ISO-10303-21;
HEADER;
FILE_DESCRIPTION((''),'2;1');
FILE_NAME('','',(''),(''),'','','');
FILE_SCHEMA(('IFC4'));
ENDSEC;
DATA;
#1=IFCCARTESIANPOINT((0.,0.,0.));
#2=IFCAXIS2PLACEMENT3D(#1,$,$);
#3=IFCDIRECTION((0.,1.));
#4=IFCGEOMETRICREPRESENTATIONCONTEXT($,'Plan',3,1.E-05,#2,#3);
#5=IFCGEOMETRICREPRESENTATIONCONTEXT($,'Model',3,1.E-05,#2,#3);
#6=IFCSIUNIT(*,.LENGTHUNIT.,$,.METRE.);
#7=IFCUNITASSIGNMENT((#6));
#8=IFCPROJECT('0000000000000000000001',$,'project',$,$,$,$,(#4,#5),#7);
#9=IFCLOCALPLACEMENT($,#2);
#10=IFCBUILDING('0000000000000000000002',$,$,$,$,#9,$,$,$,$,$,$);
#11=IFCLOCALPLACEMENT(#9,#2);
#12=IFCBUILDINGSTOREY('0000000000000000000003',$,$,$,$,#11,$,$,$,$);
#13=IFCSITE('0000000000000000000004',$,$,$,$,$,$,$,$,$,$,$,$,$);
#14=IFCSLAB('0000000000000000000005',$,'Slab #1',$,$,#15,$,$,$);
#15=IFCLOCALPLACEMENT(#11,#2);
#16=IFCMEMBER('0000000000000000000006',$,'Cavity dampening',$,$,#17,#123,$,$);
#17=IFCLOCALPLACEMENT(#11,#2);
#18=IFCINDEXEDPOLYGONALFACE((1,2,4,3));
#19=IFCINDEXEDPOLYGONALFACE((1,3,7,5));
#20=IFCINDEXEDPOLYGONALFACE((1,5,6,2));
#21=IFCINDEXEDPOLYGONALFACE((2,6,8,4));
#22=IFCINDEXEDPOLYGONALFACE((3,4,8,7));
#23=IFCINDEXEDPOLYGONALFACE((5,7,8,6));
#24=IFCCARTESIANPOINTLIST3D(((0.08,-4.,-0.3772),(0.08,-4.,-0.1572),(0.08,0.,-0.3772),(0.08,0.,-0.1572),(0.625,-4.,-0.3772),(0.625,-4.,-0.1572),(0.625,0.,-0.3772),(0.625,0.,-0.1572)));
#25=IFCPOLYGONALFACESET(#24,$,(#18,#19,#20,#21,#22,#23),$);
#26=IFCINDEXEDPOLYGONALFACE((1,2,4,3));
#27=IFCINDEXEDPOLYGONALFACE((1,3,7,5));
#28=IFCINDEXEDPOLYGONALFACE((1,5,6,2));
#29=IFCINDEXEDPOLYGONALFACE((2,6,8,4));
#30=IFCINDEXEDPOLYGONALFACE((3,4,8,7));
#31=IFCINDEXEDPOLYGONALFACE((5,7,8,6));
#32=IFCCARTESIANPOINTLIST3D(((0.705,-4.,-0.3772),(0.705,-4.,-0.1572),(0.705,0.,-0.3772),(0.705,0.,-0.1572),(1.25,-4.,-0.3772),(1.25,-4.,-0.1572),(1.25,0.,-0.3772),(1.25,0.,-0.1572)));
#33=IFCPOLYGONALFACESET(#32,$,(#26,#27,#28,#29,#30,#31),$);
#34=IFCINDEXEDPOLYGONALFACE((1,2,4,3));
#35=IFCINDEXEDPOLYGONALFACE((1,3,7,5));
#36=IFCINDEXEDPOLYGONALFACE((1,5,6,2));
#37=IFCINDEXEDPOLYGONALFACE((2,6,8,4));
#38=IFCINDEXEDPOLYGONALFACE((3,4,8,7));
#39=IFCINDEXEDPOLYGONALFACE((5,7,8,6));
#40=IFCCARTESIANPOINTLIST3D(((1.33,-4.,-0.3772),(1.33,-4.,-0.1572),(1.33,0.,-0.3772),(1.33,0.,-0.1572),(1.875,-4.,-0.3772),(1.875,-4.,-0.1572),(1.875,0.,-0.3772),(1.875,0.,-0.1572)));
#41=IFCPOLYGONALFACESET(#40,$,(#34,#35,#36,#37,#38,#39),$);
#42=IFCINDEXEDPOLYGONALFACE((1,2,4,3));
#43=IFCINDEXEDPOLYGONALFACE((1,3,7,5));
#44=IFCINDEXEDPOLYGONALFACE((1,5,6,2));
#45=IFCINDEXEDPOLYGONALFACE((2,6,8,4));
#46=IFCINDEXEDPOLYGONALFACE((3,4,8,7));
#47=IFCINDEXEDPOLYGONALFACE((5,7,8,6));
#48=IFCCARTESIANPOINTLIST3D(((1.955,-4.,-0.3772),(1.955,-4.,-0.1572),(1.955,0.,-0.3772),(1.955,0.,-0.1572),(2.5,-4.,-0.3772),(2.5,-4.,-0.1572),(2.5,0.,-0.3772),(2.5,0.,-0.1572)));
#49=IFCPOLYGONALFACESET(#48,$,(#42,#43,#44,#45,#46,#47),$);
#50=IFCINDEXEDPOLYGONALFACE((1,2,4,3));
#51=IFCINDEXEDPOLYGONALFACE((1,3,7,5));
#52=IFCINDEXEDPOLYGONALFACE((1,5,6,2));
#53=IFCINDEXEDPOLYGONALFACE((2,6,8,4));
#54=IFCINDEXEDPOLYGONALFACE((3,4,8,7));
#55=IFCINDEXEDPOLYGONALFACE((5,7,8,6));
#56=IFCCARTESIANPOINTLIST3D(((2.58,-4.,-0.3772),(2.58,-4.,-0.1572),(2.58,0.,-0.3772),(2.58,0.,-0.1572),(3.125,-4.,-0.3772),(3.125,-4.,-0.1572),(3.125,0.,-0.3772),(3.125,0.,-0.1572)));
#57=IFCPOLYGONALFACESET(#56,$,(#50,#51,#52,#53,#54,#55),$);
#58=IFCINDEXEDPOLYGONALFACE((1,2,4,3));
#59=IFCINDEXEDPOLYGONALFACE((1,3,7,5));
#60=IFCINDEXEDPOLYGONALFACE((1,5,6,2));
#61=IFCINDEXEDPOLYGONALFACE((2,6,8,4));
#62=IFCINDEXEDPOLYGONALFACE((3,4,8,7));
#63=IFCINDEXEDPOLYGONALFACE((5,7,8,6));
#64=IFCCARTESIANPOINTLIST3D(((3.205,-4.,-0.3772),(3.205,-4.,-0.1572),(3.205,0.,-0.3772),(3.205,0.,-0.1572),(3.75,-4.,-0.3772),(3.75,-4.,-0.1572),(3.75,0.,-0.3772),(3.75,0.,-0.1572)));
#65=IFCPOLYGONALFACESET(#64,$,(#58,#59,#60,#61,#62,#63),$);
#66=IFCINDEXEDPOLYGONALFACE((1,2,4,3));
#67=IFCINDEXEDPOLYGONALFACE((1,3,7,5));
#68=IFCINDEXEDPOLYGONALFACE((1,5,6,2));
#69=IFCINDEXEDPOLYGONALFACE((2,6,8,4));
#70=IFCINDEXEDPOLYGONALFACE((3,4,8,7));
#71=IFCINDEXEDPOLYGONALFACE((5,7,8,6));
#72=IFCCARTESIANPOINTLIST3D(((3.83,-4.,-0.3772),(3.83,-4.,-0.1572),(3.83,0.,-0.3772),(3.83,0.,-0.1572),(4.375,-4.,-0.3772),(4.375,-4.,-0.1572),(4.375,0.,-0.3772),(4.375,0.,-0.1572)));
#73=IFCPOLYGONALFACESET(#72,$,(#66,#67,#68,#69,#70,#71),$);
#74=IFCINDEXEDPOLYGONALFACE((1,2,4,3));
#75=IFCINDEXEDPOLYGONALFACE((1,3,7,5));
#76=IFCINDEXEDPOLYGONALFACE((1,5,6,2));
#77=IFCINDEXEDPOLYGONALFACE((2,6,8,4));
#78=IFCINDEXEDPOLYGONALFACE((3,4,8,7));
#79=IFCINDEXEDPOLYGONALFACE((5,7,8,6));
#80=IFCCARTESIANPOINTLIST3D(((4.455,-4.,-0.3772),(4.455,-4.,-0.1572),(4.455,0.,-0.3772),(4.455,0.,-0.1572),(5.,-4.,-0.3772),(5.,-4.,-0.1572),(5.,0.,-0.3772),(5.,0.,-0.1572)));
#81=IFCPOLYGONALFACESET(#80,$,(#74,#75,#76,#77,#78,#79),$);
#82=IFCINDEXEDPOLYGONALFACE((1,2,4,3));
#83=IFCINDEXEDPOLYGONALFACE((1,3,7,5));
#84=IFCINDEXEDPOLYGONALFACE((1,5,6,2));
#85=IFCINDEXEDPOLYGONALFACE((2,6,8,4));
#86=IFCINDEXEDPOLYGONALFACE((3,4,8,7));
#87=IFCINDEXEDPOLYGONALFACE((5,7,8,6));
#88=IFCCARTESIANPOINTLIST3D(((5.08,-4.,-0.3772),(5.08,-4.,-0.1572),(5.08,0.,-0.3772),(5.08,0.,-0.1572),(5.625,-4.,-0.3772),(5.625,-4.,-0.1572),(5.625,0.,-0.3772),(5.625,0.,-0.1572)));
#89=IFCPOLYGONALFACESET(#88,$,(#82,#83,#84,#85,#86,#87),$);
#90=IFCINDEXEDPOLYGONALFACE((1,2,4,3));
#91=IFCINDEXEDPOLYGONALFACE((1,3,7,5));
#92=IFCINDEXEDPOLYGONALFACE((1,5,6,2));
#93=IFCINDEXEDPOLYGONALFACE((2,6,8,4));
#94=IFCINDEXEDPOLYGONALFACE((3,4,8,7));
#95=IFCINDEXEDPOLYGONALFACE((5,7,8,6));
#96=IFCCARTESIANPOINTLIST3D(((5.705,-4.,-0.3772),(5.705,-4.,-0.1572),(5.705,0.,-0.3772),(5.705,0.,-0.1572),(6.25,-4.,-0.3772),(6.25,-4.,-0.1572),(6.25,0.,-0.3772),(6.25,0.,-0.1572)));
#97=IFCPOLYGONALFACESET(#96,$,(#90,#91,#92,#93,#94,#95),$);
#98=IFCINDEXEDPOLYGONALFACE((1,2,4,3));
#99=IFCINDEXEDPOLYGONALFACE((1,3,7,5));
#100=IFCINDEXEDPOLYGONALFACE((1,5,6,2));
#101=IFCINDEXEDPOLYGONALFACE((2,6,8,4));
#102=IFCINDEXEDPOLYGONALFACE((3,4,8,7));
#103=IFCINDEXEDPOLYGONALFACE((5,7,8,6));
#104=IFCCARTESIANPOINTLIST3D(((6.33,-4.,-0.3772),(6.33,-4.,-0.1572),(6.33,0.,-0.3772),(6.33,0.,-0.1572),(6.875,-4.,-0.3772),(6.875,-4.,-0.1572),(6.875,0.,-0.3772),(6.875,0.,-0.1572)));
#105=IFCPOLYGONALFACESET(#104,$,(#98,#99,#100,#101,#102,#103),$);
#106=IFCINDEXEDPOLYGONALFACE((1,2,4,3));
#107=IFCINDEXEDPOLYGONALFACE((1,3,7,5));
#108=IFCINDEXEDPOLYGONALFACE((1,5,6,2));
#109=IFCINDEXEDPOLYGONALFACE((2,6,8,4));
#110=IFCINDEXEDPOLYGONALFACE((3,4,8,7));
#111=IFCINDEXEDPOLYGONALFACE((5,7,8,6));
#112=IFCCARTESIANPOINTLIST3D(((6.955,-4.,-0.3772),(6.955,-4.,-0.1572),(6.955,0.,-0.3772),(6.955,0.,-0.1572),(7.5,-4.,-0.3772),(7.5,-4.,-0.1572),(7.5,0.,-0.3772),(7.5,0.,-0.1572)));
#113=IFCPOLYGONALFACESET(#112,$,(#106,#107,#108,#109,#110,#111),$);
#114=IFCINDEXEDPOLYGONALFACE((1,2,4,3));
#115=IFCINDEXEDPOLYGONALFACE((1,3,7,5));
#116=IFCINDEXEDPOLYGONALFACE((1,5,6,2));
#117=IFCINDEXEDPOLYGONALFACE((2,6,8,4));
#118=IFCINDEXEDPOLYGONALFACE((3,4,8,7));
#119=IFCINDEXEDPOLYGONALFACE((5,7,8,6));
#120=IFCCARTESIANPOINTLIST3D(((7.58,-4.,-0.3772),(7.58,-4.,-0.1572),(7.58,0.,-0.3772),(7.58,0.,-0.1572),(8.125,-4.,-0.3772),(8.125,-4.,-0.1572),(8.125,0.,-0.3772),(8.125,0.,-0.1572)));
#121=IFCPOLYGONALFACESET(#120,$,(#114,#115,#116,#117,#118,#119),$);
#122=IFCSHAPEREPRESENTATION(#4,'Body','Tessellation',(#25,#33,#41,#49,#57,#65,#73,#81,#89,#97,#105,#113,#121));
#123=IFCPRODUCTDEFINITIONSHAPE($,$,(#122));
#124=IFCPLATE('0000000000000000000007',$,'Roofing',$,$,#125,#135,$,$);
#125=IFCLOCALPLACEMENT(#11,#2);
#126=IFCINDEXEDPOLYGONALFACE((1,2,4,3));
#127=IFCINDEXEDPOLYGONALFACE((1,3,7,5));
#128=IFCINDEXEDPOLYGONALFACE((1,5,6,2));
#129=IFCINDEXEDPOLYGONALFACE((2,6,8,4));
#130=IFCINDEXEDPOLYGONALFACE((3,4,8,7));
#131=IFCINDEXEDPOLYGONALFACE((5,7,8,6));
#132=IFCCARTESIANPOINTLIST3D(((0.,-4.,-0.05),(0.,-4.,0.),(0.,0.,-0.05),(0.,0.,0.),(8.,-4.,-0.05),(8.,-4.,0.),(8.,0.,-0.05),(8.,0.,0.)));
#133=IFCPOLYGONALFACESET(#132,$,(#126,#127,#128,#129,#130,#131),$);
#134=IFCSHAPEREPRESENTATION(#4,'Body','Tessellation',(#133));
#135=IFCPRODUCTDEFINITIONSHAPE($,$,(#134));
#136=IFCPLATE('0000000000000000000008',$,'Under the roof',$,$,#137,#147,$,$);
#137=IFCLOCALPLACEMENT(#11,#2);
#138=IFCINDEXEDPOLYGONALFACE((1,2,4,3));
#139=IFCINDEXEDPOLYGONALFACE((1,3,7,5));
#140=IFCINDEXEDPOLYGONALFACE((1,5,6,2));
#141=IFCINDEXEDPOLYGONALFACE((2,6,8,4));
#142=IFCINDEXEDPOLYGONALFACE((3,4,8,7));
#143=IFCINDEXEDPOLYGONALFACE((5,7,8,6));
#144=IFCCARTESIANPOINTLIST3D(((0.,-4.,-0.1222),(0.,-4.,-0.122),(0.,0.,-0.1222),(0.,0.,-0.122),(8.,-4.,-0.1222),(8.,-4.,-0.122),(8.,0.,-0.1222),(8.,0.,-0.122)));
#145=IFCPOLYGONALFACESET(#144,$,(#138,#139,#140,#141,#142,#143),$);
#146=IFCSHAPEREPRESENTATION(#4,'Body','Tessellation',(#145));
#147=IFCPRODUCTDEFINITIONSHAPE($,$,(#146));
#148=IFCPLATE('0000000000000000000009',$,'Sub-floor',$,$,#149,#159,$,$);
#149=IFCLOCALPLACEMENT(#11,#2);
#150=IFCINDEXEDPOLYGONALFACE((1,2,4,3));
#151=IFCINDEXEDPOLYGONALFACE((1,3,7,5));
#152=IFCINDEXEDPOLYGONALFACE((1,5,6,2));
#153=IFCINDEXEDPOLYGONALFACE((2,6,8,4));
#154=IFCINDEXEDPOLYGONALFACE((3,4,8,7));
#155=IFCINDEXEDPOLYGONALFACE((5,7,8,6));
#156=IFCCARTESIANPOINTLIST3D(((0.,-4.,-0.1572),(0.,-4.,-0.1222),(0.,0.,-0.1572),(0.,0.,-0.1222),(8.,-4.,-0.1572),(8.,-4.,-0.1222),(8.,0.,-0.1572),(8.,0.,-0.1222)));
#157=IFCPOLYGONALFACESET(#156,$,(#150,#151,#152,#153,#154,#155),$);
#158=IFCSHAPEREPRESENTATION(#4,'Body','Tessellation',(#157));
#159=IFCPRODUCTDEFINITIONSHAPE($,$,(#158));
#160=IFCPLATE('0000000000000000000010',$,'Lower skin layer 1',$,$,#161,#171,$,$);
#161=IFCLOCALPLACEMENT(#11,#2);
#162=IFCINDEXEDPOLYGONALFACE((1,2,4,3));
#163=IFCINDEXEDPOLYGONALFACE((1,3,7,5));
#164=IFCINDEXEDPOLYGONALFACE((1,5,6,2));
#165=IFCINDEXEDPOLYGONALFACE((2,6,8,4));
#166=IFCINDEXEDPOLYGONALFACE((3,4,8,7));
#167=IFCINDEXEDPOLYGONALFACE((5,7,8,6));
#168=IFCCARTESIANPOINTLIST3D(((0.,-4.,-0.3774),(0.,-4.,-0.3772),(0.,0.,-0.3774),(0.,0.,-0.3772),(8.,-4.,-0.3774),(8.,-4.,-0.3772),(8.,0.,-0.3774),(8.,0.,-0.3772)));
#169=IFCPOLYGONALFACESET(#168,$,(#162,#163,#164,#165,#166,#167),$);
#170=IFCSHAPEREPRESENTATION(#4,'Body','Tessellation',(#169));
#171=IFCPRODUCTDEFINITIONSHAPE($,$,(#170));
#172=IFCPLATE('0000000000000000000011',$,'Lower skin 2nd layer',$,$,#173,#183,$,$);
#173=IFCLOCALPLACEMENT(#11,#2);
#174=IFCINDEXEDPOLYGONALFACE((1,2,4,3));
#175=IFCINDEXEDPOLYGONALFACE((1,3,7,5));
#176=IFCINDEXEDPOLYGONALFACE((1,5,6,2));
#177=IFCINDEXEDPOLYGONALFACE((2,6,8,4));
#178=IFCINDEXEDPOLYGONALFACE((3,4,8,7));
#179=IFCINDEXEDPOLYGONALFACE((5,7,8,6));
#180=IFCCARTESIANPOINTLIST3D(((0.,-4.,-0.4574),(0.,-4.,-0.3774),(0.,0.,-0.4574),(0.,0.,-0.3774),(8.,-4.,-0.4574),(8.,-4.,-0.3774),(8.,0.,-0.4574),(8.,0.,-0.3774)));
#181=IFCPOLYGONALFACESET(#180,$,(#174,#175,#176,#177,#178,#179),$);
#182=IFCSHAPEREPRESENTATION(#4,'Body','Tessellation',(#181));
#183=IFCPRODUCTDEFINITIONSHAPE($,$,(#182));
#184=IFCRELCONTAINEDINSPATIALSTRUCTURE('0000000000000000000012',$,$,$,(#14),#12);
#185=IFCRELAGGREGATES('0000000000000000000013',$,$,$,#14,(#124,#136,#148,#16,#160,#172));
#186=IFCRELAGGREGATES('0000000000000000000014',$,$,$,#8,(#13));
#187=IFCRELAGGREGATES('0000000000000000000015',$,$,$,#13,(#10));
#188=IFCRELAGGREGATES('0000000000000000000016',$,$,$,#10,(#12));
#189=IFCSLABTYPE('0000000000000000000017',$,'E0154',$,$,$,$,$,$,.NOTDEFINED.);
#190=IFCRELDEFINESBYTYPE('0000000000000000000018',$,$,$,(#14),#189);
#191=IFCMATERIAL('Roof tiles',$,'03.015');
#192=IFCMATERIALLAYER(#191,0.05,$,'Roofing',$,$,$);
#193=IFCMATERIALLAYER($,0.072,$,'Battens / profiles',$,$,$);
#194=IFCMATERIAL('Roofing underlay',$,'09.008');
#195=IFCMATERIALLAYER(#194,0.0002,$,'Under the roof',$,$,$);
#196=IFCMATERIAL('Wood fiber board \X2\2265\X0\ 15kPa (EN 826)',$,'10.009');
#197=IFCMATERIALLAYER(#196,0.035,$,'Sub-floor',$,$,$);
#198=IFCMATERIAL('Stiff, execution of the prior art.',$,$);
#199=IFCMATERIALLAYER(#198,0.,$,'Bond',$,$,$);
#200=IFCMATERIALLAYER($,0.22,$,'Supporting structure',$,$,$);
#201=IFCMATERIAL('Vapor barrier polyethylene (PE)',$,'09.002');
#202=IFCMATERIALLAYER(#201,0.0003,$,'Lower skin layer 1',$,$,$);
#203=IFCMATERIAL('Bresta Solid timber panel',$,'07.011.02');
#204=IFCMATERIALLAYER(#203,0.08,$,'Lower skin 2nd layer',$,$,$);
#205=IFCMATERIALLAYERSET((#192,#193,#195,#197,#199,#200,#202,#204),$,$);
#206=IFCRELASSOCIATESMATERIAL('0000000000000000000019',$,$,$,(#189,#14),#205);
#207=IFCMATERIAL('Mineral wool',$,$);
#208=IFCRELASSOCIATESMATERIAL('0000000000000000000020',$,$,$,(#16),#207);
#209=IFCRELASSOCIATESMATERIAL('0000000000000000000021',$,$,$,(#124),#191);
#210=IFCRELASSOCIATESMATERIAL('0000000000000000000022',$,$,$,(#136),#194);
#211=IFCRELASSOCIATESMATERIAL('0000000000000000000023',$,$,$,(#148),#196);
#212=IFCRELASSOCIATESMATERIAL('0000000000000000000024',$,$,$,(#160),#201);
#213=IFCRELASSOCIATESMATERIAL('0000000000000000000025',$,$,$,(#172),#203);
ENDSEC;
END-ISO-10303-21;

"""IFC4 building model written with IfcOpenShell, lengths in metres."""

from ifc_helpers import new_model, si_unit, direction, frame, frame_2d, origin, origin_with_axes, place, context, project, spatial, rectangle, extrude, material, layer, layer_set, type_object, element, aggregate, save


model = new_model("IFC4")

# Units and contexts
plan_context = context("Plan", 3, precision=1e-05, world=origin(), true_north=direction((0.0, 1.0)))
model_context = context("Model", 3, precision=1e-05, world=origin(), true_north=direction((0.0, 1.0)))
ifc_project = project(units=[si_unit("LENGTHUNIT", "METRE")], contexts=[plan_context, model_context])

# Site, building, storey
site = spatial("IfcSite", under=ifc_project)
building_placement = place(None, origin())
building = spatial("IfcBuilding", under=site, at=building_placement)
storey_placement = place(building_placement, origin())
storey = spatial("IfcBuildingStorey", under=building, at=storey_placement)

# Slab, member, plates
ifc_material_1 = material(Name="Roof tiles", Category="03.015")
ifc_layer_1 = layer(ifc_material_1, 0.05, Name="Roofing")
ifc_layer_2 = layer(None, 0.072, Name="Battens / profiles")
ifc_material_2 = material(Name="Roofing underlay", Category="09.008")
ifc_layer_3 = layer(ifc_material_2, 0.0002, Name="Under the roof")
ifc_material_3 = material(Name="Wood fiber board ≥ 15kPa (EN 826)", Category="10.009")
ifc_layer_4 = layer(ifc_material_3, 0.035, Name="Sub-floor")
ifc_material_4 = material(Name="Stiff, execution of the prior art.")
ifc_layer_5 = layer(ifc_material_4, 0.0, Name="Bond")
ifc_layer_6 = layer(None, 0.22, Name="Supporting structure")
ifc_material_5 = material(Name="Vapor barrier polyethylene (PE)", Category="09.002")
ifc_layer_7 = layer(ifc_material_5, 0.0003, Name="Lower skin layer 1")
ifc_material_6 = material(Name="Bresta Solid timber panel", Category="07.011.02")
ifc_layer_8 = layer(ifc_material_6, 0.08, Name="Lower skin 2nd layer")
ifc_layer_set = layer_set([ifc_layer_1, ifc_layer_2, ifc_layer_3, ifc_layer_4, ifc_layer_5, ifc_layer_6, ifc_layer_7, ifc_layer_8])
slab_type = type_object("IfcSlabType", Name="E0154", PredefinedType="NOTDEFINED", material=ifc_layer_set)
slab_placement = place(None, frame((0.0, 0.0, 0.0), z_axis=(0.0, 0.0, -1.0), x_axis=(1.0, 0.0, 0.0)))
slab = element("IfcSlab", 1, at=slab_placement, inside=storey, type_object=slab_type, material=ifc_layer_set, Name="Slab #1")
ifc_material_7 = material(Name="Mineral wool")
member_1_placement = place(slab_placement, origin())
member_1 = element("IfcMember", 2, at=member_1_placement, material=ifc_material_7, Name="Cavity dampening", context=plan_context, shape_type="SweptSolid", body=[
    extrude(rectangle(XDim=0.545, YDim=0.22, at=frame_2d((0.2725, 0.11), x_axis=(1.0, 0.0))), frame((0.08, 4.0, 0.1572), z_axis=(0.0, -1.0, 0.0), x_axis=(1.0, 0.0, 0.0)), (0.0, 0.0, 1.0), 4.0),
    extrude(rectangle(XDim=0.545, YDim=0.22, at=frame_2d((0.2725, 0.11), x_axis=(1.0, 0.0))), frame((0.705, 4.0, 0.1572), z_axis=(0.0, -1.0, 0.0), x_axis=(1.0, 0.0, 0.0)), (0.0, 0.0, 1.0), 4.0),
    extrude(rectangle(XDim=0.545, YDim=0.22, at=frame_2d((0.2725, 0.11), x_axis=(1.0, 0.0))), frame((1.33, 4.0, 0.1572), z_axis=(0.0, -1.0, 0.0), x_axis=(1.0, 0.0, 0.0)), (0.0, 0.0, 1.0), 4.0),
    extrude(rectangle(XDim=0.545, YDim=0.22, at=frame_2d((0.2725, 0.11), x_axis=(1.0, 0.0))), frame((1.955, 4.0, 0.1572), z_axis=(0.0, -1.0, 0.0), x_axis=(1.0, 0.0, 0.0)), (0.0, 0.0, 1.0), 4.0),
    extrude(rectangle(XDim=0.545, YDim=0.22, at=frame_2d((0.2725, 0.11), x_axis=(1.0, 0.0))), frame((2.58, 4.0, 0.1572), z_axis=(0.0, -1.0, 0.0), x_axis=(1.0, 0.0, 0.0)), (0.0, 0.0, 1.0), 4.0),
    extrude(rectangle(XDim=0.545, YDim=0.22, at=frame_2d((0.2725, 0.11), x_axis=(1.0, 0.0))), frame((3.205, 4.0, 0.1572), z_axis=(0.0, -1.0, 0.0), x_axis=(1.0, 0.0, 0.0)), (0.0, 0.0, 1.0), 4.0),
    extrude(rectangle(XDim=0.545, YDim=0.22, at=frame_2d((0.2725, 0.11), x_axis=(1.0, 0.0))), frame((3.83, 4.0, 0.1572), z_axis=(0.0, -1.0, 0.0), x_axis=(1.0, 0.0, 0.0)), (0.0, 0.0, 1.0), 4.0),
    extrude(rectangle(XDim=0.545, YDim=0.22, at=frame_2d((0.2725, 0.11), x_axis=(1.0, 0.0))), frame((4.455, 4.0, 0.1572), z_axis=(0.0, -1.0, 0.0), x_axis=(1.0, 0.0, 0.0)), (0.0, 0.0, 1.0), 4.0),
    extrude(rectangle(XDim=0.545, YDim=0.22, at=frame_2d((0.2725, 0.11), x_axis=(1.0, 0.0))), frame((5.08, 4.0, 0.1572), z_axis=(0.0, -1.0, 0.0), x_axis=(1.0, 0.0, 0.0)), (0.0, 0.0, 1.0), 4.0),
    extrude(rectangle(XDim=0.545, YDim=0.22, at=frame_2d((0.2725, 0.11), x_axis=(1.0, 0.0))), frame((5.705, 4.0, 0.1572), z_axis=(0.0, -1.0, 0.0), x_axis=(1.0, 0.0, 0.0)), (0.0, 0.0, 1.0), 4.0),
    extrude(rectangle(XDim=0.545, YDim=0.22, at=frame_2d((0.2725, 0.11), x_axis=(1.0, 0.0))), frame((6.33, 4.0, 0.1572), z_axis=(0.0, -1.0, 0.0), x_axis=(1.0, 0.0, 0.0)), (0.0, 0.0, 1.0), 4.0),
    extrude(rectangle(XDim=0.545, YDim=0.22, at=frame_2d((0.2725, 0.11), x_axis=(1.0, 0.0))), frame((6.955, 4.0, 0.1572), z_axis=(0.0, -1.0, 0.0), x_axis=(1.0, 0.0, 0.0)), (0.0, 0.0, 1.0), 4.0),
    extrude(rectangle(XDim=0.545, YDim=0.22, at=frame_2d((0.2725, 0.11), x_axis=(1.0, 0.0))), frame((7.58, 4.0, 0.1572), z_axis=(0.0, -1.0, 0.0), x_axis=(1.0, 0.0, 0.0)), (0.0, 0.0, 1.0), 4.0),
])
plate_1_placement = place(slab_placement, origin())
plate_1 = element("IfcPlate", 3, at=plate_1_placement, material=ifc_material_1, Name="Roofing", context=plan_context, shape_type="SweptSolid", body=[
    extrude(rectangle(XDim=8.0, YDim=4.0, at=frame_2d((4.0, 2.0), x_axis=(1.0, 0.0))), origin_with_axes(), (0.0, 0.0, 1.0), 0.05),
])
plate_2_placement = place(slab_placement, origin())
plate_2 = element("IfcPlate", 4, at=plate_2_placement, material=ifc_material_2, Name="Under the roof", context=plan_context, shape_type="SweptSolid", body=[
    extrude(rectangle(XDim=8.0, YDim=4.0, at=frame_2d((4.0, 2.0), x_axis=(1.0, 0.0))), frame((0.0, 0.0, 0.122), z_axis=(0.0, 0.0, 1.0), x_axis=(1.0, 0.0, 0.0)), (0.0, 0.0, 1.0), 0.0002),
])
plate_3_placement = place(slab_placement, origin())
plate_3 = element("IfcPlate", 5, at=plate_3_placement, material=ifc_material_3, Name="Sub-floor", context=plan_context, shape_type="SweptSolid", body=[
    extrude(rectangle(XDim=8.0, YDim=4.0, at=frame_2d((4.0, 2.0), x_axis=(1.0, 0.0))), frame((0.0, 0.0, 0.1222), z_axis=(0.0, 0.0, 1.0), x_axis=(1.0, 0.0, 0.0)), (0.0, 0.0, 1.0), 0.035),
])
plate_4_placement = place(slab_placement, origin())
plate_4 = element("IfcPlate", 6, at=plate_4_placement, material=ifc_material_5, Name="Lower skin layer 1", context=plan_context, shape_type="SweptSolid", body=[
    extrude(rectangle(XDim=8.0, YDim=4.0, at=frame_2d((4.0, 2.0), x_axis=(1.0, 0.0))), frame((0.0, 0.0, 0.3772), z_axis=(0.0, 0.0, 1.0), x_axis=(1.0, 0.0, 0.0)), (0.0, 0.0, 1.0), 0.0003),
])
plate_5_placement = place(slab_placement, origin())
plate_5 = element("IfcPlate", 7, at=plate_5_placement, material=ifc_material_6, Name="Lower skin 2nd layer", context=plan_context, shape_type="SweptSolid", body=[
    extrude(rectangle(XDim=8.0, YDim=4.0, at=frame_2d((4.0, 2.0), x_axis=(1.0, 0.0))), frame((0.0, 0.0, 0.3774), z_axis=(0.0, 0.0, 1.0), x_axis=(1.0, 0.0, 0.0)), (0.0, 0.0, 1.0), 0.08),
])
aggregate(slab, [plate_1, plate_2, plate_3, member_1, plate_4, plate_5])

save(model, "model.ifc")
